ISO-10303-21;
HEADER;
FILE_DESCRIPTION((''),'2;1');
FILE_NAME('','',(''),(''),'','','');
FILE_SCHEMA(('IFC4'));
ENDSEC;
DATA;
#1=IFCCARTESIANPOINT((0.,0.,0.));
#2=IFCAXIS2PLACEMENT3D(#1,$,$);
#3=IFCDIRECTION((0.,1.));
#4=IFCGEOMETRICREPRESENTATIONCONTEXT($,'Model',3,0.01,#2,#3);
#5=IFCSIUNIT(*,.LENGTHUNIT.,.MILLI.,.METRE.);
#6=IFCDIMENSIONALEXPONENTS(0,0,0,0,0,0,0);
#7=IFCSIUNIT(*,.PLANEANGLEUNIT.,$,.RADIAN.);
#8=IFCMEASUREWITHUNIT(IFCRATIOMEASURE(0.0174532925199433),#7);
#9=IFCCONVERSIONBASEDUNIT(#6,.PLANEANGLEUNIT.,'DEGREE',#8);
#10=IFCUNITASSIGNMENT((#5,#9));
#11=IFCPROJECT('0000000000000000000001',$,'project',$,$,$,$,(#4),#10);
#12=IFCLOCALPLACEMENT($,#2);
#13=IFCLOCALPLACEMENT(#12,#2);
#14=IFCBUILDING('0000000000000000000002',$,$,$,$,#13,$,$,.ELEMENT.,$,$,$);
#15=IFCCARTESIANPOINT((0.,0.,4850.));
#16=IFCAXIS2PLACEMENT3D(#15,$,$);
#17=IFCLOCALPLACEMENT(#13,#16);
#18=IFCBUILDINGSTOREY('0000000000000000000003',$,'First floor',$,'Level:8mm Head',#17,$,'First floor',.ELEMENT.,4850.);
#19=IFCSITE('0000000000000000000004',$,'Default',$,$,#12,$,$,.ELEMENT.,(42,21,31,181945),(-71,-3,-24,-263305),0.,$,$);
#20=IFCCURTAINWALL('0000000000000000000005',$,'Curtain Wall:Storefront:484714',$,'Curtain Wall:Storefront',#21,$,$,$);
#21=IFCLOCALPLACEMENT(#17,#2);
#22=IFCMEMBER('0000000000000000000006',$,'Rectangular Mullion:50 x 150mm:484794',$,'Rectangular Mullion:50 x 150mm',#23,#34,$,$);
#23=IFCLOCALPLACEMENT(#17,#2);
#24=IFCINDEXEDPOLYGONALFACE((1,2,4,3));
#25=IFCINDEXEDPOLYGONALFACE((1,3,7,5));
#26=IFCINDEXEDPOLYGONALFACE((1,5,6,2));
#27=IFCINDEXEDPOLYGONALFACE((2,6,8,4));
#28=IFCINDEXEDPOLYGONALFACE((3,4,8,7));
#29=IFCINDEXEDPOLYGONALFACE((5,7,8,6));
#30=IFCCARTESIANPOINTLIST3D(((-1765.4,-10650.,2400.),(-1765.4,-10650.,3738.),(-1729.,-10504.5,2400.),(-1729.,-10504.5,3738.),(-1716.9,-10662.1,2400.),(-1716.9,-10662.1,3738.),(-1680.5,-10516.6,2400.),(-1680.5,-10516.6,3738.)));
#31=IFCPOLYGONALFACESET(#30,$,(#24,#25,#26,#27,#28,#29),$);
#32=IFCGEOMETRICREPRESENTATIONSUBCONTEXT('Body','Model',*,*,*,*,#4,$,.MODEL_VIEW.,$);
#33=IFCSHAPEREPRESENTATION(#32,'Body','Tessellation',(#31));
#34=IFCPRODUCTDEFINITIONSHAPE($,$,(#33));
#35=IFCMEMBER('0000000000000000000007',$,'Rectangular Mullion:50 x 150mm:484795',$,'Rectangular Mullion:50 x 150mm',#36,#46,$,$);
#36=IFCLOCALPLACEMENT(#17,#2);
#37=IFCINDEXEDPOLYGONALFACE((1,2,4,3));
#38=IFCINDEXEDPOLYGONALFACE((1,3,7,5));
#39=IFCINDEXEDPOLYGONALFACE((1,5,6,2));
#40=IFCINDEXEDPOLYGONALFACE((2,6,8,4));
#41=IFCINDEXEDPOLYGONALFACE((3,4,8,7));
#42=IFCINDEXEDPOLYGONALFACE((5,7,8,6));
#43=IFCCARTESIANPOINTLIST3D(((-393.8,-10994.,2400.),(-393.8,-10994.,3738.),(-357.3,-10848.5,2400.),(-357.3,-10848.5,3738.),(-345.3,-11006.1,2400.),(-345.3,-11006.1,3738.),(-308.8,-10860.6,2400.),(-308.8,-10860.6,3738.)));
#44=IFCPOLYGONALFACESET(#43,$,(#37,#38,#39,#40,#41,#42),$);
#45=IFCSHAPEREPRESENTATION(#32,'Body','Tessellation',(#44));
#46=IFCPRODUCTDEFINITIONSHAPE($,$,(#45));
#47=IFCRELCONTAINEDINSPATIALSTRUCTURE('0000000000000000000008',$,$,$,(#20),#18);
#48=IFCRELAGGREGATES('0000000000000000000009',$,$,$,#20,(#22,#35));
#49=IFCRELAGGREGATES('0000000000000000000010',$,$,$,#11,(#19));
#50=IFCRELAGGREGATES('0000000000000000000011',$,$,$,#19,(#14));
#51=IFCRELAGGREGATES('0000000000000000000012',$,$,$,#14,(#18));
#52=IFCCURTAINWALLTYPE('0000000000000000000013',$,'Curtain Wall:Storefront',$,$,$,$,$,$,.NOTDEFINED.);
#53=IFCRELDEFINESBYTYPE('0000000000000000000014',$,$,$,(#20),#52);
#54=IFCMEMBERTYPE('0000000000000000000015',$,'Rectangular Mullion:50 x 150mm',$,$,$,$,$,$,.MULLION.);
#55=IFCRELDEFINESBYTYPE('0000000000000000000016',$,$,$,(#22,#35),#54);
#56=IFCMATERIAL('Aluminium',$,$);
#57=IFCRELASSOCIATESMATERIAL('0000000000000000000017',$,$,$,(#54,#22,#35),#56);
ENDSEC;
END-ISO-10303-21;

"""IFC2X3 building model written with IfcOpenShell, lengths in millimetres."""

from ifc_helpers import new_model, entity, si_unit, converted_unit, direction, frame, origin, origin_2d_with_axis, place, context, subcontext, project, spatial, rectangle, extrude, source, transform, mapped, material, type_object, type_shapes, element, aggregate, save


model = new_model("IFC2X3")

# Units and contexts
model_context = context("Model", 3, precision=0.01, world=origin(), true_north=direction((0.0, 1.0)))
body_context = subcontext(model_context, "Body", "Model", "MODEL_VIEW")
ifc_project = project(units=[si_unit("LENGTHUNIT", "METRE", prefix="MILLI"), converted_unit("PLANEANGLEUNIT", "DEGREE", entity("IfcRatioMeasure", 0.0174532925199433), si_unit("PLANEANGLEUNIT", "RADIAN"), dimensions=[0, 0, 0, 0, 0, 0, 0])], contexts=[model_context])

# Site, building, storey
site_placement = place(None, origin())
site = spatial("IfcSite", under=ifc_project, at=site_placement, Name="Default", CompositionType="ELEMENT", RefLatitude=(42, 21, 31, 181945), RefLongitude=(-71, -3, -24, -263305), RefElevation=0.0)
building_placement = place(site_placement, origin())
building = spatial("IfcBuilding", under=site, at=building_placement, CompositionType="ELEMENT")
storey_placement = place(building_placement, frame((0.0, 0.0, 4850.0)))
storey = spatial("IfcBuildingStorey", under=building, at=storey_placement, Name="First floor", ObjectType="Level:8mm Head", LongName="First floor", CompositionType="ELEMENT", Elevation=4850.0)

# Curtain wall, members
curtain_wall_type = type_object("IfcCurtainWallType", Name="Curtain Wall:Storefront", PredefinedType="NOTDEFINED")
curtain_wall_placement = place(storey_placement, frame((0.0, 0.0, -4850.0)))
curtain_wall = element("IfcCurtainWall", 1, at=curtain_wall_placement, inside=storey, type_object=curtain_wall_type, Name="Curtain Wall:Storefront:484714", ObjectType="Curtain Wall:Storefront")
ifc_material_1 = material(Name="Aluminium")
member_type_1 = type_object("IfcMemberType", Name="Rectangular Mullion:50 x 150mm", PredefinedType="MULLION", material=ifc_material_1)
shared_shape_1 = source(origin(), body_context, "Body", "SweptSolid", [
    extrude(rectangle(XDim=150.0, YDim=50.0, at=origin_2d_with_axis()), frame((0.0, 0.0, -1338.0), z_axis=(0.0, 0.0, 1.0), x_axis=(0.0, -1.0, 0.0)), (0.0, 0.0, 1.0), 1338.0),
])
type_shapes(member_type_1, [shared_shape_1])
member_1_placement = place(storey_placement, frame((-1722.9, -10583.3, 2400.0), z_axis=(0.0, 0.0, -1.0), x_axis=(0.96996, -0.243265, 0.0)))
member_1 = element("IfcMember", 2, at=member_1_placement, type_object=member_type_1, material=ifc_material_1, Name="Rectangular Mullion:50 x 150mm:484794", ObjectType="Rectangular Mullion:50 x 150mm", context=body_context, shape_type="MappedRepresentation", body=[
    mapped(shared_shape_1, transform((0.0, 0.0, 0.0), scale=1.0)),
])
member_2_placement = place(storey_placement, frame((-351.3, -10927.3, 2400.0), z_axis=(0.0, 0.0, -1.0), x_axis=(0.96996, -0.243265, 0.0)))
member_2 = element("IfcMember", 3, at=member_2_placement, type_object=member_type_1, material=ifc_material_1, Name="Rectangular Mullion:50 x 150mm:484795", ObjectType="Rectangular Mullion:50 x 150mm", context=body_context, shape_type="MappedRepresentation", body=[
    mapped(shared_shape_1, transform((0.0, 0.0, 0.0), scale=1.0)),
])
aggregate(curtain_wall, [member_1, member_2])

save(model, "model.ifc")
